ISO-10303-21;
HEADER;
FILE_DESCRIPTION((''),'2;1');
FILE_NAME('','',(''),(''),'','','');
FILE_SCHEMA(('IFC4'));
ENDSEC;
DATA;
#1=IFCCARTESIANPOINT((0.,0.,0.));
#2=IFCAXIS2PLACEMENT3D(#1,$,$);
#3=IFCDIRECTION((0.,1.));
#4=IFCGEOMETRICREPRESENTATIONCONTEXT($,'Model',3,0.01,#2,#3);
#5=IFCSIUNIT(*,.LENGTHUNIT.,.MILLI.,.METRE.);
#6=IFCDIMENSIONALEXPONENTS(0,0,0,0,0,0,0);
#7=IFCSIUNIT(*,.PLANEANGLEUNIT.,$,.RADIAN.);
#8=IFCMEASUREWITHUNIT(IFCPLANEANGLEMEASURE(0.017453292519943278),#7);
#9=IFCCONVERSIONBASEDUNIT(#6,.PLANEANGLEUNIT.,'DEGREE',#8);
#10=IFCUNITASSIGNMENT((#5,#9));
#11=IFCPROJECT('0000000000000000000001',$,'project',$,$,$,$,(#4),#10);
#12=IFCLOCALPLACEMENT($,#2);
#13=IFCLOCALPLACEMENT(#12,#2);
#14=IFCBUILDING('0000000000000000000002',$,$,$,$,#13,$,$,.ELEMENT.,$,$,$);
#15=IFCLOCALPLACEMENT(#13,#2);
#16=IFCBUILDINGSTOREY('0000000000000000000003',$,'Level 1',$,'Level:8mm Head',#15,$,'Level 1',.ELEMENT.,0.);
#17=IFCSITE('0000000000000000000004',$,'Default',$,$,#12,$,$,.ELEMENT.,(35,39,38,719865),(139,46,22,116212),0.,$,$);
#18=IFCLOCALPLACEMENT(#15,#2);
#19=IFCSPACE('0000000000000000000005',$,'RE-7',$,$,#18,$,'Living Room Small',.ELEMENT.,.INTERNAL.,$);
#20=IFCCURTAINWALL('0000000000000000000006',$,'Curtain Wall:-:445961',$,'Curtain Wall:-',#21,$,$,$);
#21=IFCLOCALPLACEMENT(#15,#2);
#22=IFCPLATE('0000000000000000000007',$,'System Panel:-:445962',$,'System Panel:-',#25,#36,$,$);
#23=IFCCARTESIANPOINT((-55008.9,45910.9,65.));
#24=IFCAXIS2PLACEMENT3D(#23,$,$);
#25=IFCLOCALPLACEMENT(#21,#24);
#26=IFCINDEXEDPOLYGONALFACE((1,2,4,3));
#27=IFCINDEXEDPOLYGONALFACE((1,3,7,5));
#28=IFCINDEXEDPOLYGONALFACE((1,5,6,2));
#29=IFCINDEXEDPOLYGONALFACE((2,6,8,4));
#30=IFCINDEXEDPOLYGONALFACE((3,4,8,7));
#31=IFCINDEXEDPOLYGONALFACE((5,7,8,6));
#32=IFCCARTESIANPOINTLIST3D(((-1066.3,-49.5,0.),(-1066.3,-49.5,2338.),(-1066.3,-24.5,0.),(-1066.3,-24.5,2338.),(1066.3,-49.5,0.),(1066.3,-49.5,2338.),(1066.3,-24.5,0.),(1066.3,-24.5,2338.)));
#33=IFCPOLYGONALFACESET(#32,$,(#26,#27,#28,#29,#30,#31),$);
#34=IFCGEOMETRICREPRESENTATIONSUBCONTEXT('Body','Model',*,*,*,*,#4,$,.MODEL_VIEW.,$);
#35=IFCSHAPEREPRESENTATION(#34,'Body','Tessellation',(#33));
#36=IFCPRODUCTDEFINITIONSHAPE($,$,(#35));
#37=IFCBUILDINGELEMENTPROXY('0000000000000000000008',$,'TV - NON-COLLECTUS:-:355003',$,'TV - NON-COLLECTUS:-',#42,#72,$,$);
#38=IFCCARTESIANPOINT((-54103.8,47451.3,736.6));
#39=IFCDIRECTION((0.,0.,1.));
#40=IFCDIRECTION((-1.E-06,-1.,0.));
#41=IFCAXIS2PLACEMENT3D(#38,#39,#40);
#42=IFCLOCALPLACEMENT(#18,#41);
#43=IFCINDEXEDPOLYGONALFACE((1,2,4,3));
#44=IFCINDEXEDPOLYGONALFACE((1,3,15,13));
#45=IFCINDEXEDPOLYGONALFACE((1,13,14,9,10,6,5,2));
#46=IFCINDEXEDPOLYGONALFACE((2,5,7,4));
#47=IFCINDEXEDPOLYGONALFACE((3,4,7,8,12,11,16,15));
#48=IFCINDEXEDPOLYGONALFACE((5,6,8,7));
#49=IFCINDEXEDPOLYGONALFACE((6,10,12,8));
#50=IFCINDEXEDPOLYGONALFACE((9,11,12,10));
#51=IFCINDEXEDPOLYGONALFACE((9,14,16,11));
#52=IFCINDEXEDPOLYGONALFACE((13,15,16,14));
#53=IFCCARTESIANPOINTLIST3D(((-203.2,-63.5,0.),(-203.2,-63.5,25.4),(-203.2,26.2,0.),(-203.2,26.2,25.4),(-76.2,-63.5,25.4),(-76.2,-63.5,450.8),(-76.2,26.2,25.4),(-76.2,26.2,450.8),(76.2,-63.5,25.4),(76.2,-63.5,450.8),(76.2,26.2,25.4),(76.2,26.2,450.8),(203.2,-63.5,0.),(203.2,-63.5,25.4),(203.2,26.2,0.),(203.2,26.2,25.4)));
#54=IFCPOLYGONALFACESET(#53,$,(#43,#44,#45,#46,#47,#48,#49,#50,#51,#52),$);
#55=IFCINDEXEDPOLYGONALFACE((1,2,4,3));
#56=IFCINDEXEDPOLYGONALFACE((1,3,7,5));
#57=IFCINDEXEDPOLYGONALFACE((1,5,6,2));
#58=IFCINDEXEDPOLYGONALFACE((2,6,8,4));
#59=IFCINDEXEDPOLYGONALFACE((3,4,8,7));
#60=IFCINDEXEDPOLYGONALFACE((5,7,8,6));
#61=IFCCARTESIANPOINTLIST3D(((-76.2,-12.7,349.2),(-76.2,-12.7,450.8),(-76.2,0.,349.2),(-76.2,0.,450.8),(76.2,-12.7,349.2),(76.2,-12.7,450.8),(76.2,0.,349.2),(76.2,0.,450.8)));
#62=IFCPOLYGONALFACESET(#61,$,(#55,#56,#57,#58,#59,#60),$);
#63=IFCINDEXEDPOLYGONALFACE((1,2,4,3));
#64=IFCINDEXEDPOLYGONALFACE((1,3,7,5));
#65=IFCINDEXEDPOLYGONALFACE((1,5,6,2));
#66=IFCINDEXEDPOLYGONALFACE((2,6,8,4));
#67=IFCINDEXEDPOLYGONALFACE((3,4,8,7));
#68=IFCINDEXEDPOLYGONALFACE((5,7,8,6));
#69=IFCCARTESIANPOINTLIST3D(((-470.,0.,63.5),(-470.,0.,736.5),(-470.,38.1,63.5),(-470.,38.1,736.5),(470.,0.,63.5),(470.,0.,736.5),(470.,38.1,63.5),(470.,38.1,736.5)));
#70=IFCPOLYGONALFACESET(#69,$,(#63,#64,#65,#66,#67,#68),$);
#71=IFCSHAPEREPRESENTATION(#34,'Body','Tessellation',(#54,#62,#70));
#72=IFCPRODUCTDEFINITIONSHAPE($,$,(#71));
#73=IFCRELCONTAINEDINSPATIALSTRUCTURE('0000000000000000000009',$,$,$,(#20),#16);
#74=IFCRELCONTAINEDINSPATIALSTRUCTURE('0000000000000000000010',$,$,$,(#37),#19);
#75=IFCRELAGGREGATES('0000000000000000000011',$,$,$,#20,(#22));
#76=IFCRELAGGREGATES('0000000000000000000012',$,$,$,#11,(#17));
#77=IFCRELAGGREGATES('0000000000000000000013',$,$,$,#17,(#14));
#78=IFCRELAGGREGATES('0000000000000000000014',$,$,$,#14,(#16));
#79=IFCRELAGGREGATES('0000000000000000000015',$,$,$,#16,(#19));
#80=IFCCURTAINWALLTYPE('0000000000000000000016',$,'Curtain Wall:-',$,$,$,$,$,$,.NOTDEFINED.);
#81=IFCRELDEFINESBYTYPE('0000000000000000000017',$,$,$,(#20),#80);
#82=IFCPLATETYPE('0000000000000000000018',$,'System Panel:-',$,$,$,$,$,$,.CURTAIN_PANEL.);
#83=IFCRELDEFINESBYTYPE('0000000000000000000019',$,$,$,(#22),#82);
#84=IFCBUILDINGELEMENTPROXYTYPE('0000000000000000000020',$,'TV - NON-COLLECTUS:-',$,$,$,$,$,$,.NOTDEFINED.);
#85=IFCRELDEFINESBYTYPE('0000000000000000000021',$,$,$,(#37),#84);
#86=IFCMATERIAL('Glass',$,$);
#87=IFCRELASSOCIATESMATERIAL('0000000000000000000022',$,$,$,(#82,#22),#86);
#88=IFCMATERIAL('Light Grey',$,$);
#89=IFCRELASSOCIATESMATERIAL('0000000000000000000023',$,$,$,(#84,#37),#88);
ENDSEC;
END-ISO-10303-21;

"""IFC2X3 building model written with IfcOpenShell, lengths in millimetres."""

from ifc_helpers import new_model, entity, si_unit, converted_unit, direction, frame, frame_2d, origin, origin_2d_with_axis, place, context, subcontext, project, spatial, polyline, rectangle, outline, extrude, source, transform, mapped, material, type_object, type_shapes, element, aggregate, save


model = new_model("IFC2X3")

# Units and contexts
model_context = context("Model", 3, precision=0.01, world=origin(), true_north=direction((0.0, 1.0)))
body_context = subcontext(model_context, "Body", "Model", "MODEL_VIEW")
ifc_project = project(units=[si_unit("LENGTHUNIT", "METRE", prefix="MILLI"), converted_unit("PLANEANGLEUNIT", "DEGREE", entity("IfcPlaneAngleMeasure", 0.017453292519943278), si_unit("PLANEANGLEUNIT", "RADIAN"), dimensions=[0, 0, 0, 0, 0, 0, 0])], contexts=[model_context])

# Site, building, storey
site_placement = place(None, origin())
site = spatial("IfcSite", under=ifc_project, at=site_placement, Name="Default", CompositionType="ELEMENT", RefLatitude=(35, 39, 38, 719865), RefLongitude=(139, 46, 22, 116212), RefElevation=0.0)
building_placement = place(site_placement, origin())
building = spatial("IfcBuilding", under=site, at=building_placement, CompositionType="ELEMENT")
storey_placement = place(building_placement, origin())
storey = spatial("IfcBuildingStorey", under=building, at=storey_placement, Name="Level 1", ObjectType="Level:8mm Head", LongName="Level 1", CompositionType="ELEMENT", Elevation=0.0)

# Curtain wall, plate
curtain_wall_type = type_object("IfcCurtainWallType", Name="Curtain Wall:-", PredefinedType="NOTDEFINED")
curtain_wall_placement = place(storey_placement, origin())
curtain_wall = element("IfcCurtainWall", 1, at=curtain_wall_placement, inside=storey, type_object=curtain_wall_type, Name="Curtain Wall:-:445961", ObjectType="Curtain Wall:-")
ifc_material_1 = material(Name="Glass")
plate_type = type_object("IfcPlateType", Name="System Panel:-", PredefinedType="CURTAIN_PANEL", material=ifc_material_1)
shared_shape_1 = source(origin(), body_context, "Body", "SweptSolid", [
    extrude(rectangle(XDim=25.0, YDim=2132.6, at=frame_2d((0.0, 0.0), x_axis=(1.0, 0.0))), frame((0.0, -37.0, 0.0), z_axis=(0.0, 0.0, 1.0), x_axis=(0.0, 1.0, 0.0)), (0.0, 0.0, 1.0), 2338.0),
])
type_shapes(plate_type, [shared_shape_1])
plate_placement = place(curtain_wall_placement, frame((-55008.9, 45910.9, 65.0)))
plate = element("IfcPlate", 2, at=plate_placement, type_object=plate_type, material=ifc_material_1, Name="System Panel:-:445962", ObjectType="System Panel:-", context=body_context, shape_type="MappedRepresentation", body=[
    mapped(shared_shape_1, transform((0.0, 0.0, 0.0), scale=1.0)),
])
aggregate(curtain_wall, [plate])

# Shared definitions
space_1_placement = place(storey_placement, origin())
space_1 = spatial("IfcSpace", under=storey, at=space_1_placement, Name="RE-7", LongName="Living Room Small", CompositionType="ELEMENT", InteriorOrExteriorSpace="INTERNAL")

# Building element proxy
ifc_material_2 = material(Name="Light Grey")
building_element_proxy_type_1 = type_object("IfcBuildingElementProxyType", Name="TV - NON-COLLECTUS:-", PredefinedType="NOTDEFINED", material=ifc_material_2)
shared_shape_2 = source(origin(), body_context, "Body", "SweptSolid", [
    extrude(outline(polyline([(-325.4, 76.2), (-325.4, -76.2), (100.0, -76.2), (100.0, -203.2), (125.4, -203.2), (125.4, 203.2), (100.0, 203.2), (100.0, 76.2), (-325.4, 76.2)])), frame((0.0, -63.5, 125.4), z_axis=(0.0, -1.0, 0.0), x_axis=(0.0, 0.0, -1.0)), (0.0, 0.0, -1.0), 89.7),
    extrude(rectangle(XDim=152.4, YDim=12.7, at=origin_2d_with_axis()), frame((0.0, -6.4, 349.2), z_axis=(0.0, 0.0, 1.0), x_axis=(-1.0, 0.0, 0.0)), (0.0, 0.0, 1.0), 101.6),
    extrude(rectangle(XDim=38.1, YDim=940.0, at=origin_2d_with_axis()), frame((0.0, 19.1, 63.5), z_axis=(0.0, 0.0, 1.0), x_axis=(0.0, 1.0, 0.0)), (0.0, 0.0, 1.0), 673.0),
])
type_shapes(building_element_proxy_type_1, [shared_shape_2])
proxy_1_placement = place(space_1_placement, frame((-54103.8, 47451.3, 736.6), z_axis=(0.0, 0.0, 1.0), x_axis=(-0.000001, -1.0, 0.0)))
element("IfcBuildingElementProxy", 3, at=proxy_1_placement, inside=space_1, type_object=building_element_proxy_type_1, material=ifc_material_2, Name="TV - NON-COLLECTUS:-:355003", ObjectType="TV - NON-COLLECTUS:-", context=body_context, shape_type="MappedRepresentation", body=[
    mapped(shared_shape_2, transform((0.0, 0.0, 0.0), scale=1.0)),
])

save(model, "model.ifc")
